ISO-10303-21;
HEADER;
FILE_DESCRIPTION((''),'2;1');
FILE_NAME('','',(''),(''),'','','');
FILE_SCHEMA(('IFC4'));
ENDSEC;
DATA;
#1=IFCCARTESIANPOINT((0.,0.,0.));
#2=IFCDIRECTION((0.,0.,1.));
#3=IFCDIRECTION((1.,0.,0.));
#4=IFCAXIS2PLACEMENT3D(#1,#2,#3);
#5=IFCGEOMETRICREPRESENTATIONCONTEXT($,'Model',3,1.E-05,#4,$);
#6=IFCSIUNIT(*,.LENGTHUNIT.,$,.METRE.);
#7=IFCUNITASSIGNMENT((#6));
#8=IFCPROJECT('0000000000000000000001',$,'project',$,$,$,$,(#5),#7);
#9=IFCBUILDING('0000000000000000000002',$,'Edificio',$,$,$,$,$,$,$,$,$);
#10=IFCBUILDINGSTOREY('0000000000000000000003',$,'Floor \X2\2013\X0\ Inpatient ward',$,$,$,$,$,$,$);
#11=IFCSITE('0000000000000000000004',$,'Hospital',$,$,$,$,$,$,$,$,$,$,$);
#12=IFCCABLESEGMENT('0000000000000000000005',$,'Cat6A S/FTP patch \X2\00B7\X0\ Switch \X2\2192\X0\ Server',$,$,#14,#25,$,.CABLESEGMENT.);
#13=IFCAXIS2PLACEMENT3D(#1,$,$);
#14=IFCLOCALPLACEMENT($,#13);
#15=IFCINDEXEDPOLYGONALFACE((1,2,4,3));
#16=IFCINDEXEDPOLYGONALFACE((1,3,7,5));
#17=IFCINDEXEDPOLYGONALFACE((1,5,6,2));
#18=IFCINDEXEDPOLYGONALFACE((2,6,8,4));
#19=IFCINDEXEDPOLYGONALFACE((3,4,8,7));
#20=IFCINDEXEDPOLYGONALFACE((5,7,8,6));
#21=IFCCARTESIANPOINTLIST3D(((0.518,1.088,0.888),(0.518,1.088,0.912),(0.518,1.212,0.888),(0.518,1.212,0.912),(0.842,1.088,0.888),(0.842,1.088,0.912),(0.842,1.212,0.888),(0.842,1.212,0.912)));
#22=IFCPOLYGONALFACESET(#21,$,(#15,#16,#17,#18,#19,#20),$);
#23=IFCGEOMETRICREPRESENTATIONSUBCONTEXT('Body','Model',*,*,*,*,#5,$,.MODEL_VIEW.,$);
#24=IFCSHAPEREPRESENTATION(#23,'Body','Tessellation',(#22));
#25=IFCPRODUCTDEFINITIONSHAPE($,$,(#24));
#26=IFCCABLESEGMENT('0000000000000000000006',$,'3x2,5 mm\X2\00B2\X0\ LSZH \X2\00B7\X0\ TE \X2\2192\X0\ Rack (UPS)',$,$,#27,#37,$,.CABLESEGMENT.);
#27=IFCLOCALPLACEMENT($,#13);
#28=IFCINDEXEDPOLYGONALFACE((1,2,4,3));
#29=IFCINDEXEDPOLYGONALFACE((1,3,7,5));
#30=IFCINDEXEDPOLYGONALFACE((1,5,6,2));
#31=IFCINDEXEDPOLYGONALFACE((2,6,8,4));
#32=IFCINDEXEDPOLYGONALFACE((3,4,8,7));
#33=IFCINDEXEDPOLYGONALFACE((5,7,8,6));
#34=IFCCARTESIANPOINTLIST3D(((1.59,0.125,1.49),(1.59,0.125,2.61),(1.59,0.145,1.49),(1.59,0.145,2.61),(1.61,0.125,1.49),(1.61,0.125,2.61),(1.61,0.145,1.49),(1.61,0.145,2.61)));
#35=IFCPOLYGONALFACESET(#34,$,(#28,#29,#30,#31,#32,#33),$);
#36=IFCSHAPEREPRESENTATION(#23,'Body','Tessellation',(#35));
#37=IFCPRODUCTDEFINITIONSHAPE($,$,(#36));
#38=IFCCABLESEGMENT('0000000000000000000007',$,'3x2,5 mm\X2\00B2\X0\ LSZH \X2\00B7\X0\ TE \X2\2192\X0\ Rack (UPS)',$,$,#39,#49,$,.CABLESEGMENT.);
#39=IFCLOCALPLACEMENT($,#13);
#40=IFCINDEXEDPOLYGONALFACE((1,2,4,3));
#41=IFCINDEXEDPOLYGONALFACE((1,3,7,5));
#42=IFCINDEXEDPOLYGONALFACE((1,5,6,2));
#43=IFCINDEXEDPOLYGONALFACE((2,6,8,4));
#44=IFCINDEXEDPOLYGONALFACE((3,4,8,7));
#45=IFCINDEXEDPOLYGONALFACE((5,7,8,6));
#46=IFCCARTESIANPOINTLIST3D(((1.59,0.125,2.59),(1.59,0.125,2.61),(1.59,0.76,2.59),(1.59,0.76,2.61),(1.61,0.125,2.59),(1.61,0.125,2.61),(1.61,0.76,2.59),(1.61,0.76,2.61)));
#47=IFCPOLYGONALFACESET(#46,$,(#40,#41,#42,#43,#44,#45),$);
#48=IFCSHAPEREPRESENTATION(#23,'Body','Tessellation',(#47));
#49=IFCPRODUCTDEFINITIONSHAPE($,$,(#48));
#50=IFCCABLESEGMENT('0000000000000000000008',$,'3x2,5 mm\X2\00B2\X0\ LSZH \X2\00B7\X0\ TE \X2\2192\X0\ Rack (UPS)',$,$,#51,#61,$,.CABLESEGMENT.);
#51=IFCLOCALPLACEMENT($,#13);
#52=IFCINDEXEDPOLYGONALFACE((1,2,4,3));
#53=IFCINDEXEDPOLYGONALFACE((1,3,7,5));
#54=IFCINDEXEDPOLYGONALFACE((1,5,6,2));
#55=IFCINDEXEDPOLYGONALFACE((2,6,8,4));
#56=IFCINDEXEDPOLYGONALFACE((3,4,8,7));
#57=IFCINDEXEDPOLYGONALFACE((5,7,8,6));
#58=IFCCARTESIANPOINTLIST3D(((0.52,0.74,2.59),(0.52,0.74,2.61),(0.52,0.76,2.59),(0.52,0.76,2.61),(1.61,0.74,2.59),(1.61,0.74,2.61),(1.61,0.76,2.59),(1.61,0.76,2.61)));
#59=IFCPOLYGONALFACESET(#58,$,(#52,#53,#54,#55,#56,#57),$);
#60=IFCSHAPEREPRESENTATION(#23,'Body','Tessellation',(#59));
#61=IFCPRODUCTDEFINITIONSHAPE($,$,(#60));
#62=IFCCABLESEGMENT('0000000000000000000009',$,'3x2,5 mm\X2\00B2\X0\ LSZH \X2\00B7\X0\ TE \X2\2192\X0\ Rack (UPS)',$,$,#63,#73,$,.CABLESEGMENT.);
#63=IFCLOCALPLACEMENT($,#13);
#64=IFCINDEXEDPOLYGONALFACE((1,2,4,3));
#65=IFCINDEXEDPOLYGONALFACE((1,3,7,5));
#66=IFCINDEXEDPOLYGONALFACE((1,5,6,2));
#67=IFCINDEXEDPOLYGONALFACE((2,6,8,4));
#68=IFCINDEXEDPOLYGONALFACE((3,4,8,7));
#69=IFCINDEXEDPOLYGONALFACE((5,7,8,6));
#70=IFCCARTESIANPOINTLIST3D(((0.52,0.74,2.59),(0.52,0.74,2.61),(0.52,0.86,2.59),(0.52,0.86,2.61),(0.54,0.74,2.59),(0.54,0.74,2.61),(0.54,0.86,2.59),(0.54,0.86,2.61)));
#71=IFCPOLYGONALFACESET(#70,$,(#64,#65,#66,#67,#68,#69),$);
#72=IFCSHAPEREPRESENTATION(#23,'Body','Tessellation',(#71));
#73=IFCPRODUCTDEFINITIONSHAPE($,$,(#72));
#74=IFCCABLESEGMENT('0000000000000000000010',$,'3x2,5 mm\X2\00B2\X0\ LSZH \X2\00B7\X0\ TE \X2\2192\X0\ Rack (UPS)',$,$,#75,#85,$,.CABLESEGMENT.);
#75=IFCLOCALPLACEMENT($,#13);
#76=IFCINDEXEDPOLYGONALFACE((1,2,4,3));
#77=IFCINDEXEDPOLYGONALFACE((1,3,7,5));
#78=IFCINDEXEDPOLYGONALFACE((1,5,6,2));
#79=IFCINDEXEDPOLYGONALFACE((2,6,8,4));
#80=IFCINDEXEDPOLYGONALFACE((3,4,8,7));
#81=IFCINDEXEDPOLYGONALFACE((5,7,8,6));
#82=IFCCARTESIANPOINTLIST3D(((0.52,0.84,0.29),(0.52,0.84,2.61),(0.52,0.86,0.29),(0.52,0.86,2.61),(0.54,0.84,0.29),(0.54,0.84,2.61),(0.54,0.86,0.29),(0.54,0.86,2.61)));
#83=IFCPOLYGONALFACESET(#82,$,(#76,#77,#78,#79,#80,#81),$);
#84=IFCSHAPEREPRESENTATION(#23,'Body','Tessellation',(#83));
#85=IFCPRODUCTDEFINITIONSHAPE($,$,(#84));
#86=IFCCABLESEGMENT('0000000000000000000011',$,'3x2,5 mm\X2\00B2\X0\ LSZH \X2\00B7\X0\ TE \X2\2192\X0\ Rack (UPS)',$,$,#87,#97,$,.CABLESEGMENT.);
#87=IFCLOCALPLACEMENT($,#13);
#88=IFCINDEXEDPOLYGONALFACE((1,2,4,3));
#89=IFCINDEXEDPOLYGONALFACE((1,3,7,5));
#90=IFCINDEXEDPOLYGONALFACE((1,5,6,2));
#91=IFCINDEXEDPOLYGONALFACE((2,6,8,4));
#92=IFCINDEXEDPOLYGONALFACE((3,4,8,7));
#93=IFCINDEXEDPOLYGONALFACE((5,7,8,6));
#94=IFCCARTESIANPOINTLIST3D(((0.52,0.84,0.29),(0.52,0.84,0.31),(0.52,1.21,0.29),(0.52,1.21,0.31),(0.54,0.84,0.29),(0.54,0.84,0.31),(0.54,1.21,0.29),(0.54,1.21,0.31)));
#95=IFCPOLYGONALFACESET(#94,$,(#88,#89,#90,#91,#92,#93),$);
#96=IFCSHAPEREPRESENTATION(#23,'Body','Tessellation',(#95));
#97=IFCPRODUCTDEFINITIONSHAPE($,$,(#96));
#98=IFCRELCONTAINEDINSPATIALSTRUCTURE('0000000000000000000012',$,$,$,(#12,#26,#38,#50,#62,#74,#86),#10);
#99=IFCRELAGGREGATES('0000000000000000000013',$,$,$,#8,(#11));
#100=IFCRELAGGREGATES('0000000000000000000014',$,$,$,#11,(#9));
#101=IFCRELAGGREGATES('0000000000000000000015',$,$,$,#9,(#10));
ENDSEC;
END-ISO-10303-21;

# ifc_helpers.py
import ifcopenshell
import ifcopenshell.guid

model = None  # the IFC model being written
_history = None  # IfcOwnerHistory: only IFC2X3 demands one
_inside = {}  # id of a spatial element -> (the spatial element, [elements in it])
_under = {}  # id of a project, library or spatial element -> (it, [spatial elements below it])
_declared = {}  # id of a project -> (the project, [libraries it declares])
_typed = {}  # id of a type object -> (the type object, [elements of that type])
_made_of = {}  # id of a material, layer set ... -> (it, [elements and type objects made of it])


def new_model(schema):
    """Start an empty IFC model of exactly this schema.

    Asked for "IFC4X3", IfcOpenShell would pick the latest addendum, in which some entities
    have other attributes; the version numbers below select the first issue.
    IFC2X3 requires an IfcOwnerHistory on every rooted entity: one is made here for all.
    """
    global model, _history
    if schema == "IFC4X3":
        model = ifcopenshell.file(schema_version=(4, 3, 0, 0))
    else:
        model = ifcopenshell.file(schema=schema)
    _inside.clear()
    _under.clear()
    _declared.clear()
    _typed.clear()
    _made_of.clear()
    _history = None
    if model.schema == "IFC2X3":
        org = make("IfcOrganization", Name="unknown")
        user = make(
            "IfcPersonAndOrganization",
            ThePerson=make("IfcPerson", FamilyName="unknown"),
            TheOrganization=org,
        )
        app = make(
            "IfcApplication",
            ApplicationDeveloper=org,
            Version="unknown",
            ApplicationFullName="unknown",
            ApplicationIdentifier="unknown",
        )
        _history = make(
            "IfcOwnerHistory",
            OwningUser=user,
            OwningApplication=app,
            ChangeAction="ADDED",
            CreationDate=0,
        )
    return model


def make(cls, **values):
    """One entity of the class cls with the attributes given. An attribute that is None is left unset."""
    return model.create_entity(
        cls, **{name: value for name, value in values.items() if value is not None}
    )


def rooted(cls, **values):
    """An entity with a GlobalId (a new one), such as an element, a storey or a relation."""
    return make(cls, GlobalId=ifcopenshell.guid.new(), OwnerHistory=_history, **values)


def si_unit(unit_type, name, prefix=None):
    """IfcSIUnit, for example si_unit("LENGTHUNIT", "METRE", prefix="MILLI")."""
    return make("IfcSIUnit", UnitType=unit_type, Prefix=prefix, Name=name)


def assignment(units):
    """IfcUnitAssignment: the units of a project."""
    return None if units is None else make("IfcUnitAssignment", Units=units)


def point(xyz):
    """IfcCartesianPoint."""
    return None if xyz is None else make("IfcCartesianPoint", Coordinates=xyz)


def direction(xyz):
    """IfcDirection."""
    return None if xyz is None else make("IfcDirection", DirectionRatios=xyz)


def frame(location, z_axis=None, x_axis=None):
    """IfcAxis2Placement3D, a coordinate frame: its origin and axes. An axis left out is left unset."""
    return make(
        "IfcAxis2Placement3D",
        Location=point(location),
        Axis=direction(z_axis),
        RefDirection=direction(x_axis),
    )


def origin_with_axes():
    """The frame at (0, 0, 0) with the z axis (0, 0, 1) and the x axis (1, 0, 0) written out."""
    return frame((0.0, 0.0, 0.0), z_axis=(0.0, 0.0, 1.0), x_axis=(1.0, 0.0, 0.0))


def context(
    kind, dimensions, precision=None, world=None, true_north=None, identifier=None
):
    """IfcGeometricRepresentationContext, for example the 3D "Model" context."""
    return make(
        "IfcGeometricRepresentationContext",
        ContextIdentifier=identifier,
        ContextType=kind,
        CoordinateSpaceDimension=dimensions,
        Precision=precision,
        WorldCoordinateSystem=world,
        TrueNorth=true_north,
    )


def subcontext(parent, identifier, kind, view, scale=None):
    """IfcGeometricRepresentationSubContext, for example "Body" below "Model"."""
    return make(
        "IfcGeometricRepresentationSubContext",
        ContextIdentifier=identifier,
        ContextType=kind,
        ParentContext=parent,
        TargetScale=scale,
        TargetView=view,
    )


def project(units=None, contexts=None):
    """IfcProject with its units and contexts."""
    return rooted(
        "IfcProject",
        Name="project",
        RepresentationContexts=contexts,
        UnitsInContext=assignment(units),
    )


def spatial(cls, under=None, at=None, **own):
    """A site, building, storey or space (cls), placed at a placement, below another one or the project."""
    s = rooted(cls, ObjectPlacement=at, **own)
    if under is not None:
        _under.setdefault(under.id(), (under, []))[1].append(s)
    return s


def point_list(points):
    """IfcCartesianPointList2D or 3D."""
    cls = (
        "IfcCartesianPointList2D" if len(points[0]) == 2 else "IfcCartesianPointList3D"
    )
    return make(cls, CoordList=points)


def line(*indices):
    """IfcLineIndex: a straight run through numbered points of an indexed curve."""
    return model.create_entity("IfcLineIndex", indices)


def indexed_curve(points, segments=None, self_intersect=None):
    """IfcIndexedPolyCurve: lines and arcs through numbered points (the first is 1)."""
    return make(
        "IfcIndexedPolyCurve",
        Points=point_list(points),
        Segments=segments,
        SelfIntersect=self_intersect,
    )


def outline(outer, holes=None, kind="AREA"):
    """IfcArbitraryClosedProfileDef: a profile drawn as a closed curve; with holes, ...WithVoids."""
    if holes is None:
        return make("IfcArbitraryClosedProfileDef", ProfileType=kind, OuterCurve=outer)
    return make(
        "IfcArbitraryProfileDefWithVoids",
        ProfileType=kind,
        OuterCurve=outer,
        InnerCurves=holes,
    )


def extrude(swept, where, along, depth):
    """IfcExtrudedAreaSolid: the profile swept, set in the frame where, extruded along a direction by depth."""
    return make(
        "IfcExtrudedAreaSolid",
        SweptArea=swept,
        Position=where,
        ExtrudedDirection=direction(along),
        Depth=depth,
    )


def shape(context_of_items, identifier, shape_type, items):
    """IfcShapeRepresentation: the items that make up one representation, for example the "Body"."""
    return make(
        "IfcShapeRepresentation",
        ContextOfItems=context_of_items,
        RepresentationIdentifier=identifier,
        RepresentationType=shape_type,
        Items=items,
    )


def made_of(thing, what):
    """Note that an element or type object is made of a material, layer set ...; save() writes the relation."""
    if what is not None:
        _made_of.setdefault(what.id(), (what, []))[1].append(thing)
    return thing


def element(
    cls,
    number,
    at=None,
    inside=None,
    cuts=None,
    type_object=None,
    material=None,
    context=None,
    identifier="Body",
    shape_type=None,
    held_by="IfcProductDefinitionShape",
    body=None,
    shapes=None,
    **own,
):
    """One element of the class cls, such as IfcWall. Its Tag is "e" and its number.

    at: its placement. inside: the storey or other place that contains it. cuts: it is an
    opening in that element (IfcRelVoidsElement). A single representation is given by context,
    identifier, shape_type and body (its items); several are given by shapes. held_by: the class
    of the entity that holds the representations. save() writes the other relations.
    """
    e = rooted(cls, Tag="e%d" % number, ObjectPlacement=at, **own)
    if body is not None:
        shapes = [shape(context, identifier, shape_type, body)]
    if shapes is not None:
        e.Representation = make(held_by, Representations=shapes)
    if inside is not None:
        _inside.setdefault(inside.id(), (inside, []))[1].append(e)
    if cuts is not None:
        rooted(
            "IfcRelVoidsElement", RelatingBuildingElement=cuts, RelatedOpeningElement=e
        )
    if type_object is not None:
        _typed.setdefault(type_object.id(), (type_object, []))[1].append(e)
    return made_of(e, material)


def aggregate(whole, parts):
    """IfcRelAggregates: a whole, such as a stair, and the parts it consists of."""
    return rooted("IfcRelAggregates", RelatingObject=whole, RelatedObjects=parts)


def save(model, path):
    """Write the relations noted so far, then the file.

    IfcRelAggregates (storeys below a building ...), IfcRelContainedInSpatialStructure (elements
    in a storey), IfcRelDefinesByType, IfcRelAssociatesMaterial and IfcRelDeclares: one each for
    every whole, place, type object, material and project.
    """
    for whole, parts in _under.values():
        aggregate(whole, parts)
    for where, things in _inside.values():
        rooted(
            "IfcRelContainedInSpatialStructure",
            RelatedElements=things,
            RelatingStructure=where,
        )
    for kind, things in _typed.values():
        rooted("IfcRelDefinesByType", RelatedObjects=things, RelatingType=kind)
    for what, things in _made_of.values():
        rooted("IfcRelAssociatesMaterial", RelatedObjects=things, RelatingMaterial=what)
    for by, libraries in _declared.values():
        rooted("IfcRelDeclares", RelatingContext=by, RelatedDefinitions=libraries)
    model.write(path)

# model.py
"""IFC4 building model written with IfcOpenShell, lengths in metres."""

from ifc_helpers import new_model, si_unit, frame, origin_with_axes, context, subcontext, project, spatial, line, indexed_curve, outline, extrude, element, save


model = new_model("IFC4")

# Units and contexts
model_context = context("Model", 3, precision=1e-05, world=origin_with_axes())
body_context = subcontext(model_context, "Body", "Model", "MODEL_VIEW")
ifc_project = project(units=[si_unit("LENGTHUNIT", "METRE")], contexts=[model_context])

# Site, building, storey
site = spatial("IfcSite", under=ifc_project, Name="Hospital")
building = spatial("IfcBuilding", under=site, Name="Edificio")
storey = spatial("IfcBuildingStorey", under=building, Name="Floor – Inpatient ward")

# Cable segments
element("IfcCableSegment", 1, inside=storey, Name="Cat6A S/FTP patch · Switch → Server", PredefinedType="CABLESEGMENT", context=body_context, shape_type="SweptSolid", body=[
    extrude(outline(indexed_curve([(0.0, 0.0), (0.324, 0.0), (0.324, 0.124), (0.0, 0.124)], segments=[line(1, 2, 3, 4, 1)])), frame((0.518, 1.088, 0.888), z_axis=(0.0, 0.0, 1.0), x_axis=(1.0, 0.0, 0.0)), (0.0, 0.0, 1.0), 0.024),
])
element("IfcCableSegment", 2, inside=storey, Name="3x2,5 mm² LSZH · TE → Rack (UPS)", PredefinedType="CABLESEGMENT", context=body_context, shape_type="SweptSolid", body=[
    extrude(outline(indexed_curve([(0.0, 0.0), (0.02, 0.0), (0.02, 0.02), (0.0, 0.02)], segments=[line(1, 2, 3, 4, 1)])), frame((1.59, 0.125, 1.49), z_axis=(0.0, 0.0, 1.0), x_axis=(1.0, 0.0, 0.0)), (0.0, 0.0, 1.0), 1.12),
])
element("IfcCableSegment", 3, inside=storey, Name="3x2,5 mm² LSZH · TE → Rack (UPS)", PredefinedType="CABLESEGMENT", context=body_context, shape_type="SweptSolid", body=[
    extrude(outline(indexed_curve([(0.0, 0.0), (0.02, 0.0), (0.02, 0.635), (0.0, 0.635)], segments=[line(1, 2, 3, 4, 1)])), frame((1.59, 0.125, 2.59), z_axis=(0.0, 0.0, 1.0), x_axis=(1.0, 0.0, 0.0)), (0.0, 0.0, 1.0), 0.02),
])
element("IfcCableSegment", 4, inside=storey, Name="3x2,5 mm² LSZH · TE → Rack (UPS)", PredefinedType="CABLESEGMENT", context=body_context, shape_type="SweptSolid", body=[
    extrude(outline(indexed_curve([(0.0, 0.0), (1.09, 0.0), (1.09, 0.02), (0.0, 0.02)], segments=[line(1, 2, 3, 4, 1)])), frame((0.52, 0.74, 2.59), z_axis=(0.0, 0.0, 1.0), x_axis=(1.0, 0.0, 0.0)), (0.0, 0.0, 1.0), 0.02),
])
element("IfcCableSegment", 5, inside=storey, Name="3x2,5 mm² LSZH · TE → Rack (UPS)", PredefinedType="CABLESEGMENT", context=body_context, shape_type="SweptSolid", body=[
    extrude(outline(indexed_curve([(0.0, 0.0), (0.02, 0.0), (0.02, 0.12), (0.0, 0.12)], segments=[line(1, 2, 3, 4, 1)])), frame((0.52, 0.74, 2.59), z_axis=(0.0, 0.0, 1.0), x_axis=(1.0, 0.0, 0.0)), (0.0, 0.0, 1.0), 0.02),
])
element("IfcCableSegment", 6, inside=storey, Name="3x2,5 mm² LSZH · TE → Rack (UPS)", PredefinedType="CABLESEGMENT", context=body_context, shape_type="SweptSolid", body=[
    extrude(outline(indexed_curve([(0.0, 0.0), (0.02, 0.0), (0.02, 0.02), (0.0, 0.02)], segments=[line(1, 2, 3, 4, 1)])), frame((0.52, 0.84, 0.29), z_axis=(0.0, 0.0, 1.0), x_axis=(1.0, 0.0, 0.0)), (0.0, 0.0, 1.0), 2.32),
])
element("IfcCableSegment", 7, inside=storey, Name="3x2,5 mm² LSZH · TE → Rack (UPS)", PredefinedType="CABLESEGMENT", context=body_context, shape_type="SweptSolid", body=[
    extrude(outline(indexed_curve([(0.0, 0.0), (0.02, 0.0), (0.02, 0.37), (0.0, 0.37)], segments=[line(1, 2, 3, 4, 1)])), frame((0.52, 0.84, 0.29), z_axis=(0.0, 0.0, 1.0), x_axis=(1.0, 0.0, 0.0)), (0.0, 0.0, 1.0), 0.02),
])

save(model, "model.ifc")
